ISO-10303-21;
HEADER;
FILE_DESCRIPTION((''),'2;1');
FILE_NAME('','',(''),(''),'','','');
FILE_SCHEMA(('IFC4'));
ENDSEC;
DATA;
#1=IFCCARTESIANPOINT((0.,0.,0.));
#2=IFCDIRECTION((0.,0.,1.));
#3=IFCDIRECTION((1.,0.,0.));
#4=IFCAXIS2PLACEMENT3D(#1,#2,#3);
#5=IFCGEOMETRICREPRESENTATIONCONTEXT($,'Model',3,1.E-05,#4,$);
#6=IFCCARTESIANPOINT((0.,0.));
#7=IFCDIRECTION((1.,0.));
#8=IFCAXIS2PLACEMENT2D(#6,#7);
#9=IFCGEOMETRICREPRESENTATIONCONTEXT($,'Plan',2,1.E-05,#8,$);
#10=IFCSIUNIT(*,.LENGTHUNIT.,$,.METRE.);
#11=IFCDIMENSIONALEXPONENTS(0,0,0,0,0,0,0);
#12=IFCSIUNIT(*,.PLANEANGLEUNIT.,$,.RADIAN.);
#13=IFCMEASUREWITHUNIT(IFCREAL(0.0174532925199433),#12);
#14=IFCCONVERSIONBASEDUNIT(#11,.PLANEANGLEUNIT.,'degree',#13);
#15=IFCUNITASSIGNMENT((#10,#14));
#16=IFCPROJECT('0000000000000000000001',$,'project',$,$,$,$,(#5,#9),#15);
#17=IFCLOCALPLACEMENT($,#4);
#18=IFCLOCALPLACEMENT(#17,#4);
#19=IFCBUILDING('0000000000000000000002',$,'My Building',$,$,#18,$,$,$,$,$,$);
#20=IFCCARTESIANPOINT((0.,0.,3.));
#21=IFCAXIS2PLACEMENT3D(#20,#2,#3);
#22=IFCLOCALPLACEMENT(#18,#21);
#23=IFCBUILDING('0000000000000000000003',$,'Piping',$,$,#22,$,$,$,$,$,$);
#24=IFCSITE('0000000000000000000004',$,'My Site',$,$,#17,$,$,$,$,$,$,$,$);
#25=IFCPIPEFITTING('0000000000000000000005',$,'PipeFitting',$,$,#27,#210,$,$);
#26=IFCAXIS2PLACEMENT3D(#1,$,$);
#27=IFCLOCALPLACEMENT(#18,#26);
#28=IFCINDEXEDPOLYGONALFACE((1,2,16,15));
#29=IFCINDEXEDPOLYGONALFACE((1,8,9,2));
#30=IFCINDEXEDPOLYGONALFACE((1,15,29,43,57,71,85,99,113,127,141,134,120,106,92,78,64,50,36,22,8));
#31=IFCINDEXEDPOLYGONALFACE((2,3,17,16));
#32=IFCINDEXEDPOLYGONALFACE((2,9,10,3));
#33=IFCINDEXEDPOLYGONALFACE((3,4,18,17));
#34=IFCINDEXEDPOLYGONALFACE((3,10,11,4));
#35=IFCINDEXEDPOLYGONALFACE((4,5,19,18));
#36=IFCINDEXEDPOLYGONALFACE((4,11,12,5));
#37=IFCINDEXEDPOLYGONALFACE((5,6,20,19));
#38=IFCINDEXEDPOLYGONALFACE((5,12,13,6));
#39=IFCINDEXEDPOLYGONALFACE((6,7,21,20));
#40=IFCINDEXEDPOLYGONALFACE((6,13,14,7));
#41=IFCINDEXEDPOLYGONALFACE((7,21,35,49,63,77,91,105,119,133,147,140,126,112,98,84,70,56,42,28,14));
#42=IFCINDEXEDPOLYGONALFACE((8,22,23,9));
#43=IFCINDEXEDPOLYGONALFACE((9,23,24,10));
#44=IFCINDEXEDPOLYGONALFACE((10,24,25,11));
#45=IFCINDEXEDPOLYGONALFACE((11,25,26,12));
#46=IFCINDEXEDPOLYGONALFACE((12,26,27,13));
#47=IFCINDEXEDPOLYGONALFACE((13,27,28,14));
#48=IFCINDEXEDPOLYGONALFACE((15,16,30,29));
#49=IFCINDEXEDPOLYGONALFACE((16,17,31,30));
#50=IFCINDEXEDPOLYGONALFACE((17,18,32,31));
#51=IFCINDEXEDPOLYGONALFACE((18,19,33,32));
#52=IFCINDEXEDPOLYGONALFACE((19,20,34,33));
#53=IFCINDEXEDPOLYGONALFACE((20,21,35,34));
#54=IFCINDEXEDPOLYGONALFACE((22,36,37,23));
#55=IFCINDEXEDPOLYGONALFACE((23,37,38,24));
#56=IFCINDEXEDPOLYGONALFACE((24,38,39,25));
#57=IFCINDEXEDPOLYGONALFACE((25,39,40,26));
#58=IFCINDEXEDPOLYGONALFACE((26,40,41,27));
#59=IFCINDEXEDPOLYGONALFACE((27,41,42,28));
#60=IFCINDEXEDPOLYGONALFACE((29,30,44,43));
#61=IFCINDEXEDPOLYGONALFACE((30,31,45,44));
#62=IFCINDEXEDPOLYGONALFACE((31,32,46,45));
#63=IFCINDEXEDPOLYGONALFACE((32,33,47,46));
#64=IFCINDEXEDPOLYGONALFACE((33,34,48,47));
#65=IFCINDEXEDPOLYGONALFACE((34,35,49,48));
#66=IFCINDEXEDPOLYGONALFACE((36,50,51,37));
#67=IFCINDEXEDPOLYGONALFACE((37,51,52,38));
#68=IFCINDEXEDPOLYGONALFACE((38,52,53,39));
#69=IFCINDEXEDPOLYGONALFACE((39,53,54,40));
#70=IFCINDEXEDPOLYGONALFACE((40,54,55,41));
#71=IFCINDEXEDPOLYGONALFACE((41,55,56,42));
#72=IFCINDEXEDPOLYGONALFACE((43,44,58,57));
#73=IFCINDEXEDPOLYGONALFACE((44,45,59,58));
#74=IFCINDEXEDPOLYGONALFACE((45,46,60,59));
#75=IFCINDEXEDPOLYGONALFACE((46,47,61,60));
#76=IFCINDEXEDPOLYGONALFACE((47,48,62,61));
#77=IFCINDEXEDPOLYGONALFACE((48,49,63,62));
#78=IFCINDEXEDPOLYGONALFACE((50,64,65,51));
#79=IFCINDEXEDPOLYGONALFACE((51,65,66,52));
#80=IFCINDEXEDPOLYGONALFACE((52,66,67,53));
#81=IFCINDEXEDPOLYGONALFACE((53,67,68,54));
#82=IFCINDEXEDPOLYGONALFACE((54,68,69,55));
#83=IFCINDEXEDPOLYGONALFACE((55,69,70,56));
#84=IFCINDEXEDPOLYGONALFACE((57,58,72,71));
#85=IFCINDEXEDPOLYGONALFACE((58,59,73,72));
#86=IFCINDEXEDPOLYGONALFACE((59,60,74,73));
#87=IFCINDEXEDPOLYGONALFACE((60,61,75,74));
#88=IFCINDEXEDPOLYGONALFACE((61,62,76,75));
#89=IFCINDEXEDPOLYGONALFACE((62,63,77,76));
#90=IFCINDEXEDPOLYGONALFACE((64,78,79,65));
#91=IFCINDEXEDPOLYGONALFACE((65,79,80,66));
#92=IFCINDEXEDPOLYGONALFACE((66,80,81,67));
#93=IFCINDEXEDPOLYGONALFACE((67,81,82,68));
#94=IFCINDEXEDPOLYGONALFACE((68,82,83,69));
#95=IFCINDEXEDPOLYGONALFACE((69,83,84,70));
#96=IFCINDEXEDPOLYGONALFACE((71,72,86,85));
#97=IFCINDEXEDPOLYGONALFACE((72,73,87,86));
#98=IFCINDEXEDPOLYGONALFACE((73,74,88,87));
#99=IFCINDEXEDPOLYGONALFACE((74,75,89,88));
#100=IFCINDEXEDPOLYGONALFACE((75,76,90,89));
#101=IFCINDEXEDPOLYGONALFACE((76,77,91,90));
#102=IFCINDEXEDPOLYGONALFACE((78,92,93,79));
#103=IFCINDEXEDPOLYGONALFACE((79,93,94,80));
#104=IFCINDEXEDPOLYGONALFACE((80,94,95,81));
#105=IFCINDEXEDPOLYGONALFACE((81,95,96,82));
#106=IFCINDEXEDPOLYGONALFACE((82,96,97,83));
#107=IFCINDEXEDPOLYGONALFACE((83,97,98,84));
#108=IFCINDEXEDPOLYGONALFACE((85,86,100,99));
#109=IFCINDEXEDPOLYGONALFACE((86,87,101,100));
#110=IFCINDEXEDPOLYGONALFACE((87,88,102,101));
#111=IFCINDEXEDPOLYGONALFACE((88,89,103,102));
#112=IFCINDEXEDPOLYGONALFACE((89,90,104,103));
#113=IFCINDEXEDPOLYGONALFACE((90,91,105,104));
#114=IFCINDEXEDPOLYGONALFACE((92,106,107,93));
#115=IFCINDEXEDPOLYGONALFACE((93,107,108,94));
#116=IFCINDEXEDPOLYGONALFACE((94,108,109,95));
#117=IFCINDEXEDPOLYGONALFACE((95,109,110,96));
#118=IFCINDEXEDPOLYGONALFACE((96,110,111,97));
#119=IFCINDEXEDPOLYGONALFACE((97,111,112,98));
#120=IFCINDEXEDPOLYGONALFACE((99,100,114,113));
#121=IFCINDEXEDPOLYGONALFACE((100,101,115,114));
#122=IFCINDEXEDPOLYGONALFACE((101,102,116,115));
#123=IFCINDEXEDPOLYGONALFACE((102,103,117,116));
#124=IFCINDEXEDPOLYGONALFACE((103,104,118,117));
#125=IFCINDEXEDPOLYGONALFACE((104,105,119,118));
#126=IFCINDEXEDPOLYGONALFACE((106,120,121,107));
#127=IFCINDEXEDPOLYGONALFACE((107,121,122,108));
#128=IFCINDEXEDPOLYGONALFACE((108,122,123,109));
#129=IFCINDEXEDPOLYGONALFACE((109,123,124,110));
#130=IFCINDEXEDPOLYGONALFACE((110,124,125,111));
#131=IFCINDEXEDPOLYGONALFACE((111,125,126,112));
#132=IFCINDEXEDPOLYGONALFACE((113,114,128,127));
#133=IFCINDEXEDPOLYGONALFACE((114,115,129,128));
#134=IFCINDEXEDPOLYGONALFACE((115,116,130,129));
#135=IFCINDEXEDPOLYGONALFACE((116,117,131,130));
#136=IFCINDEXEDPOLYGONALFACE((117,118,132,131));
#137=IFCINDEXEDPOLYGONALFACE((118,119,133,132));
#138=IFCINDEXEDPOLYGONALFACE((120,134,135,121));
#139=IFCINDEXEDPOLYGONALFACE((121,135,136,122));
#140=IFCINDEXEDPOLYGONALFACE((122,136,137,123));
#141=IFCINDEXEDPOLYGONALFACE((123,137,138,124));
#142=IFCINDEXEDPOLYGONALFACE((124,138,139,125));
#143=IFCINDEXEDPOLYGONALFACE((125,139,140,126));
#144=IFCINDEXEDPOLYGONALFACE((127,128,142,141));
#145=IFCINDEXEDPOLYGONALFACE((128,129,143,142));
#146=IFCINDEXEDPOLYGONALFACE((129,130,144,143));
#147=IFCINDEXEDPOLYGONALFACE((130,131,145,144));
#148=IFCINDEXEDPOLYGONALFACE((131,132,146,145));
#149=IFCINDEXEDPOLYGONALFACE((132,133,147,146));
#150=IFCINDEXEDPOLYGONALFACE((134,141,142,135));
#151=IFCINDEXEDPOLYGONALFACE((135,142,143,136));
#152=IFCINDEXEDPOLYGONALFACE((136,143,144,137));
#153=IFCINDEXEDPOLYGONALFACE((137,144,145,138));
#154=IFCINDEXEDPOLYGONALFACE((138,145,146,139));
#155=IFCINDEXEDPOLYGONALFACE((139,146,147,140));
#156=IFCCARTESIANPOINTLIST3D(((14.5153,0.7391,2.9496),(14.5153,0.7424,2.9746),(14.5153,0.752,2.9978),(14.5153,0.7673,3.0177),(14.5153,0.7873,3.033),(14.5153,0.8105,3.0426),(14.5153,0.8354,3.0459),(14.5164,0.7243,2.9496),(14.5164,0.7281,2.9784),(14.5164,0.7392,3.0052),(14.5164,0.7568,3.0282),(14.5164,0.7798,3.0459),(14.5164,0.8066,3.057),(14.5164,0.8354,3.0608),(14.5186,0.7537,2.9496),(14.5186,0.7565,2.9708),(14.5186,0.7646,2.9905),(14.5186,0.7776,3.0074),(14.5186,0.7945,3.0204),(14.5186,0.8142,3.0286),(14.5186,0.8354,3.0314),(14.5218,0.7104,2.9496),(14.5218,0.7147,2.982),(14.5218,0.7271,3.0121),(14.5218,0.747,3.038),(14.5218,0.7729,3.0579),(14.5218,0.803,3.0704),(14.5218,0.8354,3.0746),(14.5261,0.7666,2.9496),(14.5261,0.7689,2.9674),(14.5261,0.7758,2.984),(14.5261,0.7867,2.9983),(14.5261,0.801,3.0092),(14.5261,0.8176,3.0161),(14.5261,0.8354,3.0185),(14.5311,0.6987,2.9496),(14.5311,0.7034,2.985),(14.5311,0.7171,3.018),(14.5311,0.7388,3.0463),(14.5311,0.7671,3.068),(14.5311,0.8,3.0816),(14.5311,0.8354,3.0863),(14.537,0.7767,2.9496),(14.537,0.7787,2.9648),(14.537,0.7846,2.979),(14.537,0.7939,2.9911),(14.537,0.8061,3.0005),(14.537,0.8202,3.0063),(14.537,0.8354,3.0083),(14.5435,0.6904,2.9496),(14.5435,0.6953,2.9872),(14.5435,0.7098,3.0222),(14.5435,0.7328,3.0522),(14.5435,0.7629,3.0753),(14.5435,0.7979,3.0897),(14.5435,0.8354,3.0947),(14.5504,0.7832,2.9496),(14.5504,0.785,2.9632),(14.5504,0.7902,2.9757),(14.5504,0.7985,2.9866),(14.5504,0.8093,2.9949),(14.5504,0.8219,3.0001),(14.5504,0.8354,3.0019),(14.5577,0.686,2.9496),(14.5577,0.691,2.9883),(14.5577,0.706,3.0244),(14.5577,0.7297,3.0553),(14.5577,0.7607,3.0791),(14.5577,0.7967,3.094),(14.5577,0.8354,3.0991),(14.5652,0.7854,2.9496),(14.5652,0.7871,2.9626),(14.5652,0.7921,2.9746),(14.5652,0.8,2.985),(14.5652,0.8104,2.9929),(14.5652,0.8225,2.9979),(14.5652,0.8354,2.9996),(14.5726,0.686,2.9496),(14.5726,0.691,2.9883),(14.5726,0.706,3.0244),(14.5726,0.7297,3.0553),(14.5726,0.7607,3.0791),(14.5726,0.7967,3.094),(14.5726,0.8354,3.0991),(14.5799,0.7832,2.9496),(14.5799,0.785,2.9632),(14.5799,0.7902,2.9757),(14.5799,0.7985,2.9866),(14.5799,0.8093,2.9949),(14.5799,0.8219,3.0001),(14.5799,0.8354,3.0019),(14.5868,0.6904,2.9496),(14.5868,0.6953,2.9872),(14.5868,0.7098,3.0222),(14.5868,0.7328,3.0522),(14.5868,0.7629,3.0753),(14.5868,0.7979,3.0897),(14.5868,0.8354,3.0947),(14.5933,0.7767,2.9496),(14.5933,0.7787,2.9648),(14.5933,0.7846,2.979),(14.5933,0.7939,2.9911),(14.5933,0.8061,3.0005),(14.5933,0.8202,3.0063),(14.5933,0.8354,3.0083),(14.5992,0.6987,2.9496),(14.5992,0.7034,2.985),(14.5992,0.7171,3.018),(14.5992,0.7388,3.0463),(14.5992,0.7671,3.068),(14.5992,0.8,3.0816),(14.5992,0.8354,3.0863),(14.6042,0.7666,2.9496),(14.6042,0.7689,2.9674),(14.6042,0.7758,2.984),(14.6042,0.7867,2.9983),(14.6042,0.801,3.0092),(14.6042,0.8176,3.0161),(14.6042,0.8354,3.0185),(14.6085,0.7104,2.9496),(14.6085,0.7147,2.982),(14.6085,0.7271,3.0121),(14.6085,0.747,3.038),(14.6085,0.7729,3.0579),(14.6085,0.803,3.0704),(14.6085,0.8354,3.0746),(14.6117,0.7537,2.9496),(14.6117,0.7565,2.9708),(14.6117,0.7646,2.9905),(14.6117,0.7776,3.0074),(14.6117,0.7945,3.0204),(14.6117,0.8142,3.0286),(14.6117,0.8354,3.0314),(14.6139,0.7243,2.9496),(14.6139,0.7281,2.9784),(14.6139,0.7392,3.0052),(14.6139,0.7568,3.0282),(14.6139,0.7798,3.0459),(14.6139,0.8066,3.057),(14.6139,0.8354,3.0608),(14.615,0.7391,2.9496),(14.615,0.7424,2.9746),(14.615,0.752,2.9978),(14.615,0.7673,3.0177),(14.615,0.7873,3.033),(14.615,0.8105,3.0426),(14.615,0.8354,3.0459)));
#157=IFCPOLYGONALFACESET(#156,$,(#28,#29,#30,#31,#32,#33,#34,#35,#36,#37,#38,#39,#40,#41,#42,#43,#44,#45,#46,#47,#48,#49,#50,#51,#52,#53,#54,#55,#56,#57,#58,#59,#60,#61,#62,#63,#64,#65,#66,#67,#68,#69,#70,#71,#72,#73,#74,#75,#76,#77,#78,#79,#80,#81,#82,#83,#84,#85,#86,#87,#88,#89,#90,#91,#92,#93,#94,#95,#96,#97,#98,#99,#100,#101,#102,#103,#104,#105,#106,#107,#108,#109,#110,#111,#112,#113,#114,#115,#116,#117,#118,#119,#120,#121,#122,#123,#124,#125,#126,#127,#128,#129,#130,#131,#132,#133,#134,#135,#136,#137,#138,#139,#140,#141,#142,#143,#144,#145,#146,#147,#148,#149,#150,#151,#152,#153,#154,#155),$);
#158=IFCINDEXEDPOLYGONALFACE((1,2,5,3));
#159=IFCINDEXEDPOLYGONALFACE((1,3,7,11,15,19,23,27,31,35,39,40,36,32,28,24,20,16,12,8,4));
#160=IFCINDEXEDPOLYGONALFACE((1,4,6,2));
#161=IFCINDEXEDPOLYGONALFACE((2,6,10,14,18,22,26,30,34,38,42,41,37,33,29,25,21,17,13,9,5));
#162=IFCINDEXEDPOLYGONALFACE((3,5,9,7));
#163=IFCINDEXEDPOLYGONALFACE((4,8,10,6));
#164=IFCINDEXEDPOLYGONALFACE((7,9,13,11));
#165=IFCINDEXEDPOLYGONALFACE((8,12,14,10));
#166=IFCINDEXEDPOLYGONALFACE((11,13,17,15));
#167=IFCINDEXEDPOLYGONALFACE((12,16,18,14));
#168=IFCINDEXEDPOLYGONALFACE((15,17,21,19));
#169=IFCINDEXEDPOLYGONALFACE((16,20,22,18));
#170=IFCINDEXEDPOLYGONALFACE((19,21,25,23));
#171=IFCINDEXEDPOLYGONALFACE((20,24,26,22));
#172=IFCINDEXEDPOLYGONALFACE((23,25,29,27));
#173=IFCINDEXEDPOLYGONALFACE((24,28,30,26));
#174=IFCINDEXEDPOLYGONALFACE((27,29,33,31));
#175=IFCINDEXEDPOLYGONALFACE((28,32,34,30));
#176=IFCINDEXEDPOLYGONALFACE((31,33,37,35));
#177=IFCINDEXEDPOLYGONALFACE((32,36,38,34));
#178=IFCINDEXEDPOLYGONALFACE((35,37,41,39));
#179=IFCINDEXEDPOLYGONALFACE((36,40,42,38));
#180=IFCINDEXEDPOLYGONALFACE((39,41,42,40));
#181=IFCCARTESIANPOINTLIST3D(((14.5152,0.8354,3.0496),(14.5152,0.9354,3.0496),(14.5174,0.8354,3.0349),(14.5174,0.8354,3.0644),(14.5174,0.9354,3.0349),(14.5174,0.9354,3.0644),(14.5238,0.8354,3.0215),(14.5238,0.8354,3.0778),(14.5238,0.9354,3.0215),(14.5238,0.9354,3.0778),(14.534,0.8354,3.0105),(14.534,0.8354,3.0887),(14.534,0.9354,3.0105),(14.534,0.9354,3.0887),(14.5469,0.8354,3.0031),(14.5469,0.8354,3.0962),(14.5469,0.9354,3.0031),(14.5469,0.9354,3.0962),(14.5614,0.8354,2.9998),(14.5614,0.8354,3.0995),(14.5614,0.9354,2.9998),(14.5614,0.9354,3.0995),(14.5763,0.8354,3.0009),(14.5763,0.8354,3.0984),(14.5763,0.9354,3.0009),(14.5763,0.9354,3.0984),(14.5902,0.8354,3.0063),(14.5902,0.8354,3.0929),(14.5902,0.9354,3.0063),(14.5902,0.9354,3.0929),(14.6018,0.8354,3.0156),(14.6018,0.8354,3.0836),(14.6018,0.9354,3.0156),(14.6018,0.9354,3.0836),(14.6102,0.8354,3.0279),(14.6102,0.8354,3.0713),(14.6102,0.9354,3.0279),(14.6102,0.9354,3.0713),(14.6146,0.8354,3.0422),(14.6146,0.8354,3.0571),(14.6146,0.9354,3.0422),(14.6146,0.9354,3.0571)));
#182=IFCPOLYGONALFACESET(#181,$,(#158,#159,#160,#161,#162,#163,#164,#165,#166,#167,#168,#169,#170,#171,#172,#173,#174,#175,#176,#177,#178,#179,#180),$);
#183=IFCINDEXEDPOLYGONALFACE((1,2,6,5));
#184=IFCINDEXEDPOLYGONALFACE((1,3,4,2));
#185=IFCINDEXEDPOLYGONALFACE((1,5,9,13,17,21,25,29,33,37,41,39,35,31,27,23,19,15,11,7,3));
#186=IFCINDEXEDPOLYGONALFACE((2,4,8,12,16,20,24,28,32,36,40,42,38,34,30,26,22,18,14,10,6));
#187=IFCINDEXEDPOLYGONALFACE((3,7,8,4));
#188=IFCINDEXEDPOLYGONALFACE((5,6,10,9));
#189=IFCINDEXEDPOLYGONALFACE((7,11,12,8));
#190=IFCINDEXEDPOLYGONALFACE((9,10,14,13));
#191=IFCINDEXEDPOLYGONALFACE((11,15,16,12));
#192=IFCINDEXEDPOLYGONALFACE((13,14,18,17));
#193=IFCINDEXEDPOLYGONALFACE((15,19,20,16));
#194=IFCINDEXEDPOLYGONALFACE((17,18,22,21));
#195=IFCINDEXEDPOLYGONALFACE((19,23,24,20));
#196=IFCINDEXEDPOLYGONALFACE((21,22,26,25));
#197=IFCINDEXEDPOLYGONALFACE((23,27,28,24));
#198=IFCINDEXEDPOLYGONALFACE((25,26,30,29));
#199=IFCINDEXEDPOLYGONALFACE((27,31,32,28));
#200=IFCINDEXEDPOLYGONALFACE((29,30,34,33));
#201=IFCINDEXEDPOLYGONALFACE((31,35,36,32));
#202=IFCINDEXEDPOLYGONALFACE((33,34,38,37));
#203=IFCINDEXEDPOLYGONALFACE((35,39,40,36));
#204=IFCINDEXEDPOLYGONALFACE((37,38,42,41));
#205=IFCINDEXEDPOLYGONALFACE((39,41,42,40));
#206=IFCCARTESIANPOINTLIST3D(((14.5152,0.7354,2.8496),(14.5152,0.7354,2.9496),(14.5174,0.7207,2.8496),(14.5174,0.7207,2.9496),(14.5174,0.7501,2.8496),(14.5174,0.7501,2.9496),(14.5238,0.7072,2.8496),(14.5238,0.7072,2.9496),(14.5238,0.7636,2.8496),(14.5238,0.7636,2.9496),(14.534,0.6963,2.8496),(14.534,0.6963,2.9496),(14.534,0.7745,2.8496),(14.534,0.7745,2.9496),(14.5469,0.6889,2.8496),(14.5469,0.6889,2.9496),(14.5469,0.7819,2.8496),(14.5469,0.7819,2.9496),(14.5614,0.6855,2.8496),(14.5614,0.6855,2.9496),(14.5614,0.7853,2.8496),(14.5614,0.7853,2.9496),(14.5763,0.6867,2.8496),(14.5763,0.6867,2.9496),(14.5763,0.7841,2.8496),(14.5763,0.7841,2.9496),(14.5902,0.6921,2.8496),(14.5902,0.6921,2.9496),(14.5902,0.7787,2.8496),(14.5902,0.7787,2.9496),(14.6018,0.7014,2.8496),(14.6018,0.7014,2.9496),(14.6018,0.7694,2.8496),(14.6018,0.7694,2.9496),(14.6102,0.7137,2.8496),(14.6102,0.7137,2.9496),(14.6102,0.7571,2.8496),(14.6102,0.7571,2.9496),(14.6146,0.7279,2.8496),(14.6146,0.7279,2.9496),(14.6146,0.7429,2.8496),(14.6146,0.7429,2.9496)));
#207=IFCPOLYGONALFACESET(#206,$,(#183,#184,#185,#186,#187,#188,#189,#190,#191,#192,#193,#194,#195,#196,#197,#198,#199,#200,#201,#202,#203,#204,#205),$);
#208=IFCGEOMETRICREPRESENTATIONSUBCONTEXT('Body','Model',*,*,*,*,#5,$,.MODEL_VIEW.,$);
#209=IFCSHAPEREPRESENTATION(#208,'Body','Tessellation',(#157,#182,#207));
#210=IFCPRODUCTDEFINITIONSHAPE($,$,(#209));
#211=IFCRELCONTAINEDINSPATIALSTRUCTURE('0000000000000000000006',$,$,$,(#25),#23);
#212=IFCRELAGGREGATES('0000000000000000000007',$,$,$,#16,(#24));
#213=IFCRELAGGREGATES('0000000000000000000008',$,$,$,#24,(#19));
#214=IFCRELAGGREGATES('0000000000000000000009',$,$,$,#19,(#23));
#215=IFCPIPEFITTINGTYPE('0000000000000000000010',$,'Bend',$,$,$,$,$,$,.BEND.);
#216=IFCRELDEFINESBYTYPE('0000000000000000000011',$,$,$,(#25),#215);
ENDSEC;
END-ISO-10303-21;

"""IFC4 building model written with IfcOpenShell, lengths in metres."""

from ifc_helpers import new_model, entity, si_unit, converted_unit, frame, origin_with_axes, origin_2d_with_axis, place, context, subcontext, project, spatial, circle, extrude, source, transform, mapped, type_object, type_shapes, element, save


model = new_model("IFC4")

# Units and contexts
model_context = context("Model", 3, precision=1e-05, world=origin_with_axes())
plan_context = context("Plan", 2, precision=1e-05, world=origin_2d_with_axis())
body_context = subcontext(model_context, "Body", "Model", "MODEL_VIEW")
ifc_project = project(units=[si_unit("LENGTHUNIT", "METRE"), converted_unit("PLANEANGLEUNIT", "degree", entity("IfcReal", 0.0174532925199433), si_unit("PLANEANGLEUNIT", "RADIAN"), dimensions=[0, 0, 0, 0, 0, 0, 0])], contexts=[model_context, plan_context])

# Site, buildings
site_placement = place(None, origin_with_axes())
site = spatial("IfcSite", under=ifc_project, at=site_placement, Name="My Site")
building_1_placement = place(site_placement, origin_with_axes())
building_1 = spatial("IfcBuilding", under=site, at=building_1_placement, Name="My Building")
building_2_placement = place(building_1_placement, frame((0.0, 0.0, 3.0), z_axis=(0.0, 0.0, 1.0), x_axis=(1.0, 0.0, 0.0)))
building_2 = spatial("IfcBuilding", under=building_1, at=building_2_placement, Name="Piping")

# Pipe fitting
pipe_fitting_type_1 = type_object("IfcPipeFittingType", Name="Bend", PredefinedType="BEND")
shared_shape = source(origin_with_axes(), body_context, "Body", "SolidModel", [
    entity("IfcSweptDiskSolid", entity("IfcIndexedPolyCurve", entity("IfcCartesianPointList3D", [[0.0, 0.0, 0.1], [0.0, 0.0293, 0.1707], [0.0, 0.1, 0.2]]), [entity("IfcArcIndex", [1, 2, 3])]), 0.05),
    extrude(circle(Radius=0.05), origin_with_axes(), (0.0, 0.0, 1.0), 0.1),
    extrude(circle(Radius=0.05), frame((0.0, 0.1, 0.2), z_axis=(0.0, 1.0, 0.0), x_axis=(1.0, 0.0, 0.0)), (0.0, 0.0, 1.0), 0.1),
])
type_shapes(pipe_fitting_type_1, [shared_shape])
for number, where, z_axis, x_axis, name in (
    (1, (14.5652, 0.9354, 0.0496), (0.0, -1.0, 0.0), (-1.0, 0.0, 0.0), "PipeFitting"),
):
    element("IfcPipeFitting", number, at=place(building_2_placement, frame(where, z_axis=z_axis, x_axis=x_axis)), inside=building_2, type_object=pipe_fitting_type_1, Name=name, context=body_context, shape_type="MappedRepresentation", body=[
        mapped(shared_shape, transform((0.0, 0.0, 0.0), x_axis=(1.0, 0.0, 0.0), y_axis=(0.0, 1.0, 0.0), z_axis=(0.0, 0.0, 1.0), scale=1.0)),
    ])

save(model, "model.ifc")
